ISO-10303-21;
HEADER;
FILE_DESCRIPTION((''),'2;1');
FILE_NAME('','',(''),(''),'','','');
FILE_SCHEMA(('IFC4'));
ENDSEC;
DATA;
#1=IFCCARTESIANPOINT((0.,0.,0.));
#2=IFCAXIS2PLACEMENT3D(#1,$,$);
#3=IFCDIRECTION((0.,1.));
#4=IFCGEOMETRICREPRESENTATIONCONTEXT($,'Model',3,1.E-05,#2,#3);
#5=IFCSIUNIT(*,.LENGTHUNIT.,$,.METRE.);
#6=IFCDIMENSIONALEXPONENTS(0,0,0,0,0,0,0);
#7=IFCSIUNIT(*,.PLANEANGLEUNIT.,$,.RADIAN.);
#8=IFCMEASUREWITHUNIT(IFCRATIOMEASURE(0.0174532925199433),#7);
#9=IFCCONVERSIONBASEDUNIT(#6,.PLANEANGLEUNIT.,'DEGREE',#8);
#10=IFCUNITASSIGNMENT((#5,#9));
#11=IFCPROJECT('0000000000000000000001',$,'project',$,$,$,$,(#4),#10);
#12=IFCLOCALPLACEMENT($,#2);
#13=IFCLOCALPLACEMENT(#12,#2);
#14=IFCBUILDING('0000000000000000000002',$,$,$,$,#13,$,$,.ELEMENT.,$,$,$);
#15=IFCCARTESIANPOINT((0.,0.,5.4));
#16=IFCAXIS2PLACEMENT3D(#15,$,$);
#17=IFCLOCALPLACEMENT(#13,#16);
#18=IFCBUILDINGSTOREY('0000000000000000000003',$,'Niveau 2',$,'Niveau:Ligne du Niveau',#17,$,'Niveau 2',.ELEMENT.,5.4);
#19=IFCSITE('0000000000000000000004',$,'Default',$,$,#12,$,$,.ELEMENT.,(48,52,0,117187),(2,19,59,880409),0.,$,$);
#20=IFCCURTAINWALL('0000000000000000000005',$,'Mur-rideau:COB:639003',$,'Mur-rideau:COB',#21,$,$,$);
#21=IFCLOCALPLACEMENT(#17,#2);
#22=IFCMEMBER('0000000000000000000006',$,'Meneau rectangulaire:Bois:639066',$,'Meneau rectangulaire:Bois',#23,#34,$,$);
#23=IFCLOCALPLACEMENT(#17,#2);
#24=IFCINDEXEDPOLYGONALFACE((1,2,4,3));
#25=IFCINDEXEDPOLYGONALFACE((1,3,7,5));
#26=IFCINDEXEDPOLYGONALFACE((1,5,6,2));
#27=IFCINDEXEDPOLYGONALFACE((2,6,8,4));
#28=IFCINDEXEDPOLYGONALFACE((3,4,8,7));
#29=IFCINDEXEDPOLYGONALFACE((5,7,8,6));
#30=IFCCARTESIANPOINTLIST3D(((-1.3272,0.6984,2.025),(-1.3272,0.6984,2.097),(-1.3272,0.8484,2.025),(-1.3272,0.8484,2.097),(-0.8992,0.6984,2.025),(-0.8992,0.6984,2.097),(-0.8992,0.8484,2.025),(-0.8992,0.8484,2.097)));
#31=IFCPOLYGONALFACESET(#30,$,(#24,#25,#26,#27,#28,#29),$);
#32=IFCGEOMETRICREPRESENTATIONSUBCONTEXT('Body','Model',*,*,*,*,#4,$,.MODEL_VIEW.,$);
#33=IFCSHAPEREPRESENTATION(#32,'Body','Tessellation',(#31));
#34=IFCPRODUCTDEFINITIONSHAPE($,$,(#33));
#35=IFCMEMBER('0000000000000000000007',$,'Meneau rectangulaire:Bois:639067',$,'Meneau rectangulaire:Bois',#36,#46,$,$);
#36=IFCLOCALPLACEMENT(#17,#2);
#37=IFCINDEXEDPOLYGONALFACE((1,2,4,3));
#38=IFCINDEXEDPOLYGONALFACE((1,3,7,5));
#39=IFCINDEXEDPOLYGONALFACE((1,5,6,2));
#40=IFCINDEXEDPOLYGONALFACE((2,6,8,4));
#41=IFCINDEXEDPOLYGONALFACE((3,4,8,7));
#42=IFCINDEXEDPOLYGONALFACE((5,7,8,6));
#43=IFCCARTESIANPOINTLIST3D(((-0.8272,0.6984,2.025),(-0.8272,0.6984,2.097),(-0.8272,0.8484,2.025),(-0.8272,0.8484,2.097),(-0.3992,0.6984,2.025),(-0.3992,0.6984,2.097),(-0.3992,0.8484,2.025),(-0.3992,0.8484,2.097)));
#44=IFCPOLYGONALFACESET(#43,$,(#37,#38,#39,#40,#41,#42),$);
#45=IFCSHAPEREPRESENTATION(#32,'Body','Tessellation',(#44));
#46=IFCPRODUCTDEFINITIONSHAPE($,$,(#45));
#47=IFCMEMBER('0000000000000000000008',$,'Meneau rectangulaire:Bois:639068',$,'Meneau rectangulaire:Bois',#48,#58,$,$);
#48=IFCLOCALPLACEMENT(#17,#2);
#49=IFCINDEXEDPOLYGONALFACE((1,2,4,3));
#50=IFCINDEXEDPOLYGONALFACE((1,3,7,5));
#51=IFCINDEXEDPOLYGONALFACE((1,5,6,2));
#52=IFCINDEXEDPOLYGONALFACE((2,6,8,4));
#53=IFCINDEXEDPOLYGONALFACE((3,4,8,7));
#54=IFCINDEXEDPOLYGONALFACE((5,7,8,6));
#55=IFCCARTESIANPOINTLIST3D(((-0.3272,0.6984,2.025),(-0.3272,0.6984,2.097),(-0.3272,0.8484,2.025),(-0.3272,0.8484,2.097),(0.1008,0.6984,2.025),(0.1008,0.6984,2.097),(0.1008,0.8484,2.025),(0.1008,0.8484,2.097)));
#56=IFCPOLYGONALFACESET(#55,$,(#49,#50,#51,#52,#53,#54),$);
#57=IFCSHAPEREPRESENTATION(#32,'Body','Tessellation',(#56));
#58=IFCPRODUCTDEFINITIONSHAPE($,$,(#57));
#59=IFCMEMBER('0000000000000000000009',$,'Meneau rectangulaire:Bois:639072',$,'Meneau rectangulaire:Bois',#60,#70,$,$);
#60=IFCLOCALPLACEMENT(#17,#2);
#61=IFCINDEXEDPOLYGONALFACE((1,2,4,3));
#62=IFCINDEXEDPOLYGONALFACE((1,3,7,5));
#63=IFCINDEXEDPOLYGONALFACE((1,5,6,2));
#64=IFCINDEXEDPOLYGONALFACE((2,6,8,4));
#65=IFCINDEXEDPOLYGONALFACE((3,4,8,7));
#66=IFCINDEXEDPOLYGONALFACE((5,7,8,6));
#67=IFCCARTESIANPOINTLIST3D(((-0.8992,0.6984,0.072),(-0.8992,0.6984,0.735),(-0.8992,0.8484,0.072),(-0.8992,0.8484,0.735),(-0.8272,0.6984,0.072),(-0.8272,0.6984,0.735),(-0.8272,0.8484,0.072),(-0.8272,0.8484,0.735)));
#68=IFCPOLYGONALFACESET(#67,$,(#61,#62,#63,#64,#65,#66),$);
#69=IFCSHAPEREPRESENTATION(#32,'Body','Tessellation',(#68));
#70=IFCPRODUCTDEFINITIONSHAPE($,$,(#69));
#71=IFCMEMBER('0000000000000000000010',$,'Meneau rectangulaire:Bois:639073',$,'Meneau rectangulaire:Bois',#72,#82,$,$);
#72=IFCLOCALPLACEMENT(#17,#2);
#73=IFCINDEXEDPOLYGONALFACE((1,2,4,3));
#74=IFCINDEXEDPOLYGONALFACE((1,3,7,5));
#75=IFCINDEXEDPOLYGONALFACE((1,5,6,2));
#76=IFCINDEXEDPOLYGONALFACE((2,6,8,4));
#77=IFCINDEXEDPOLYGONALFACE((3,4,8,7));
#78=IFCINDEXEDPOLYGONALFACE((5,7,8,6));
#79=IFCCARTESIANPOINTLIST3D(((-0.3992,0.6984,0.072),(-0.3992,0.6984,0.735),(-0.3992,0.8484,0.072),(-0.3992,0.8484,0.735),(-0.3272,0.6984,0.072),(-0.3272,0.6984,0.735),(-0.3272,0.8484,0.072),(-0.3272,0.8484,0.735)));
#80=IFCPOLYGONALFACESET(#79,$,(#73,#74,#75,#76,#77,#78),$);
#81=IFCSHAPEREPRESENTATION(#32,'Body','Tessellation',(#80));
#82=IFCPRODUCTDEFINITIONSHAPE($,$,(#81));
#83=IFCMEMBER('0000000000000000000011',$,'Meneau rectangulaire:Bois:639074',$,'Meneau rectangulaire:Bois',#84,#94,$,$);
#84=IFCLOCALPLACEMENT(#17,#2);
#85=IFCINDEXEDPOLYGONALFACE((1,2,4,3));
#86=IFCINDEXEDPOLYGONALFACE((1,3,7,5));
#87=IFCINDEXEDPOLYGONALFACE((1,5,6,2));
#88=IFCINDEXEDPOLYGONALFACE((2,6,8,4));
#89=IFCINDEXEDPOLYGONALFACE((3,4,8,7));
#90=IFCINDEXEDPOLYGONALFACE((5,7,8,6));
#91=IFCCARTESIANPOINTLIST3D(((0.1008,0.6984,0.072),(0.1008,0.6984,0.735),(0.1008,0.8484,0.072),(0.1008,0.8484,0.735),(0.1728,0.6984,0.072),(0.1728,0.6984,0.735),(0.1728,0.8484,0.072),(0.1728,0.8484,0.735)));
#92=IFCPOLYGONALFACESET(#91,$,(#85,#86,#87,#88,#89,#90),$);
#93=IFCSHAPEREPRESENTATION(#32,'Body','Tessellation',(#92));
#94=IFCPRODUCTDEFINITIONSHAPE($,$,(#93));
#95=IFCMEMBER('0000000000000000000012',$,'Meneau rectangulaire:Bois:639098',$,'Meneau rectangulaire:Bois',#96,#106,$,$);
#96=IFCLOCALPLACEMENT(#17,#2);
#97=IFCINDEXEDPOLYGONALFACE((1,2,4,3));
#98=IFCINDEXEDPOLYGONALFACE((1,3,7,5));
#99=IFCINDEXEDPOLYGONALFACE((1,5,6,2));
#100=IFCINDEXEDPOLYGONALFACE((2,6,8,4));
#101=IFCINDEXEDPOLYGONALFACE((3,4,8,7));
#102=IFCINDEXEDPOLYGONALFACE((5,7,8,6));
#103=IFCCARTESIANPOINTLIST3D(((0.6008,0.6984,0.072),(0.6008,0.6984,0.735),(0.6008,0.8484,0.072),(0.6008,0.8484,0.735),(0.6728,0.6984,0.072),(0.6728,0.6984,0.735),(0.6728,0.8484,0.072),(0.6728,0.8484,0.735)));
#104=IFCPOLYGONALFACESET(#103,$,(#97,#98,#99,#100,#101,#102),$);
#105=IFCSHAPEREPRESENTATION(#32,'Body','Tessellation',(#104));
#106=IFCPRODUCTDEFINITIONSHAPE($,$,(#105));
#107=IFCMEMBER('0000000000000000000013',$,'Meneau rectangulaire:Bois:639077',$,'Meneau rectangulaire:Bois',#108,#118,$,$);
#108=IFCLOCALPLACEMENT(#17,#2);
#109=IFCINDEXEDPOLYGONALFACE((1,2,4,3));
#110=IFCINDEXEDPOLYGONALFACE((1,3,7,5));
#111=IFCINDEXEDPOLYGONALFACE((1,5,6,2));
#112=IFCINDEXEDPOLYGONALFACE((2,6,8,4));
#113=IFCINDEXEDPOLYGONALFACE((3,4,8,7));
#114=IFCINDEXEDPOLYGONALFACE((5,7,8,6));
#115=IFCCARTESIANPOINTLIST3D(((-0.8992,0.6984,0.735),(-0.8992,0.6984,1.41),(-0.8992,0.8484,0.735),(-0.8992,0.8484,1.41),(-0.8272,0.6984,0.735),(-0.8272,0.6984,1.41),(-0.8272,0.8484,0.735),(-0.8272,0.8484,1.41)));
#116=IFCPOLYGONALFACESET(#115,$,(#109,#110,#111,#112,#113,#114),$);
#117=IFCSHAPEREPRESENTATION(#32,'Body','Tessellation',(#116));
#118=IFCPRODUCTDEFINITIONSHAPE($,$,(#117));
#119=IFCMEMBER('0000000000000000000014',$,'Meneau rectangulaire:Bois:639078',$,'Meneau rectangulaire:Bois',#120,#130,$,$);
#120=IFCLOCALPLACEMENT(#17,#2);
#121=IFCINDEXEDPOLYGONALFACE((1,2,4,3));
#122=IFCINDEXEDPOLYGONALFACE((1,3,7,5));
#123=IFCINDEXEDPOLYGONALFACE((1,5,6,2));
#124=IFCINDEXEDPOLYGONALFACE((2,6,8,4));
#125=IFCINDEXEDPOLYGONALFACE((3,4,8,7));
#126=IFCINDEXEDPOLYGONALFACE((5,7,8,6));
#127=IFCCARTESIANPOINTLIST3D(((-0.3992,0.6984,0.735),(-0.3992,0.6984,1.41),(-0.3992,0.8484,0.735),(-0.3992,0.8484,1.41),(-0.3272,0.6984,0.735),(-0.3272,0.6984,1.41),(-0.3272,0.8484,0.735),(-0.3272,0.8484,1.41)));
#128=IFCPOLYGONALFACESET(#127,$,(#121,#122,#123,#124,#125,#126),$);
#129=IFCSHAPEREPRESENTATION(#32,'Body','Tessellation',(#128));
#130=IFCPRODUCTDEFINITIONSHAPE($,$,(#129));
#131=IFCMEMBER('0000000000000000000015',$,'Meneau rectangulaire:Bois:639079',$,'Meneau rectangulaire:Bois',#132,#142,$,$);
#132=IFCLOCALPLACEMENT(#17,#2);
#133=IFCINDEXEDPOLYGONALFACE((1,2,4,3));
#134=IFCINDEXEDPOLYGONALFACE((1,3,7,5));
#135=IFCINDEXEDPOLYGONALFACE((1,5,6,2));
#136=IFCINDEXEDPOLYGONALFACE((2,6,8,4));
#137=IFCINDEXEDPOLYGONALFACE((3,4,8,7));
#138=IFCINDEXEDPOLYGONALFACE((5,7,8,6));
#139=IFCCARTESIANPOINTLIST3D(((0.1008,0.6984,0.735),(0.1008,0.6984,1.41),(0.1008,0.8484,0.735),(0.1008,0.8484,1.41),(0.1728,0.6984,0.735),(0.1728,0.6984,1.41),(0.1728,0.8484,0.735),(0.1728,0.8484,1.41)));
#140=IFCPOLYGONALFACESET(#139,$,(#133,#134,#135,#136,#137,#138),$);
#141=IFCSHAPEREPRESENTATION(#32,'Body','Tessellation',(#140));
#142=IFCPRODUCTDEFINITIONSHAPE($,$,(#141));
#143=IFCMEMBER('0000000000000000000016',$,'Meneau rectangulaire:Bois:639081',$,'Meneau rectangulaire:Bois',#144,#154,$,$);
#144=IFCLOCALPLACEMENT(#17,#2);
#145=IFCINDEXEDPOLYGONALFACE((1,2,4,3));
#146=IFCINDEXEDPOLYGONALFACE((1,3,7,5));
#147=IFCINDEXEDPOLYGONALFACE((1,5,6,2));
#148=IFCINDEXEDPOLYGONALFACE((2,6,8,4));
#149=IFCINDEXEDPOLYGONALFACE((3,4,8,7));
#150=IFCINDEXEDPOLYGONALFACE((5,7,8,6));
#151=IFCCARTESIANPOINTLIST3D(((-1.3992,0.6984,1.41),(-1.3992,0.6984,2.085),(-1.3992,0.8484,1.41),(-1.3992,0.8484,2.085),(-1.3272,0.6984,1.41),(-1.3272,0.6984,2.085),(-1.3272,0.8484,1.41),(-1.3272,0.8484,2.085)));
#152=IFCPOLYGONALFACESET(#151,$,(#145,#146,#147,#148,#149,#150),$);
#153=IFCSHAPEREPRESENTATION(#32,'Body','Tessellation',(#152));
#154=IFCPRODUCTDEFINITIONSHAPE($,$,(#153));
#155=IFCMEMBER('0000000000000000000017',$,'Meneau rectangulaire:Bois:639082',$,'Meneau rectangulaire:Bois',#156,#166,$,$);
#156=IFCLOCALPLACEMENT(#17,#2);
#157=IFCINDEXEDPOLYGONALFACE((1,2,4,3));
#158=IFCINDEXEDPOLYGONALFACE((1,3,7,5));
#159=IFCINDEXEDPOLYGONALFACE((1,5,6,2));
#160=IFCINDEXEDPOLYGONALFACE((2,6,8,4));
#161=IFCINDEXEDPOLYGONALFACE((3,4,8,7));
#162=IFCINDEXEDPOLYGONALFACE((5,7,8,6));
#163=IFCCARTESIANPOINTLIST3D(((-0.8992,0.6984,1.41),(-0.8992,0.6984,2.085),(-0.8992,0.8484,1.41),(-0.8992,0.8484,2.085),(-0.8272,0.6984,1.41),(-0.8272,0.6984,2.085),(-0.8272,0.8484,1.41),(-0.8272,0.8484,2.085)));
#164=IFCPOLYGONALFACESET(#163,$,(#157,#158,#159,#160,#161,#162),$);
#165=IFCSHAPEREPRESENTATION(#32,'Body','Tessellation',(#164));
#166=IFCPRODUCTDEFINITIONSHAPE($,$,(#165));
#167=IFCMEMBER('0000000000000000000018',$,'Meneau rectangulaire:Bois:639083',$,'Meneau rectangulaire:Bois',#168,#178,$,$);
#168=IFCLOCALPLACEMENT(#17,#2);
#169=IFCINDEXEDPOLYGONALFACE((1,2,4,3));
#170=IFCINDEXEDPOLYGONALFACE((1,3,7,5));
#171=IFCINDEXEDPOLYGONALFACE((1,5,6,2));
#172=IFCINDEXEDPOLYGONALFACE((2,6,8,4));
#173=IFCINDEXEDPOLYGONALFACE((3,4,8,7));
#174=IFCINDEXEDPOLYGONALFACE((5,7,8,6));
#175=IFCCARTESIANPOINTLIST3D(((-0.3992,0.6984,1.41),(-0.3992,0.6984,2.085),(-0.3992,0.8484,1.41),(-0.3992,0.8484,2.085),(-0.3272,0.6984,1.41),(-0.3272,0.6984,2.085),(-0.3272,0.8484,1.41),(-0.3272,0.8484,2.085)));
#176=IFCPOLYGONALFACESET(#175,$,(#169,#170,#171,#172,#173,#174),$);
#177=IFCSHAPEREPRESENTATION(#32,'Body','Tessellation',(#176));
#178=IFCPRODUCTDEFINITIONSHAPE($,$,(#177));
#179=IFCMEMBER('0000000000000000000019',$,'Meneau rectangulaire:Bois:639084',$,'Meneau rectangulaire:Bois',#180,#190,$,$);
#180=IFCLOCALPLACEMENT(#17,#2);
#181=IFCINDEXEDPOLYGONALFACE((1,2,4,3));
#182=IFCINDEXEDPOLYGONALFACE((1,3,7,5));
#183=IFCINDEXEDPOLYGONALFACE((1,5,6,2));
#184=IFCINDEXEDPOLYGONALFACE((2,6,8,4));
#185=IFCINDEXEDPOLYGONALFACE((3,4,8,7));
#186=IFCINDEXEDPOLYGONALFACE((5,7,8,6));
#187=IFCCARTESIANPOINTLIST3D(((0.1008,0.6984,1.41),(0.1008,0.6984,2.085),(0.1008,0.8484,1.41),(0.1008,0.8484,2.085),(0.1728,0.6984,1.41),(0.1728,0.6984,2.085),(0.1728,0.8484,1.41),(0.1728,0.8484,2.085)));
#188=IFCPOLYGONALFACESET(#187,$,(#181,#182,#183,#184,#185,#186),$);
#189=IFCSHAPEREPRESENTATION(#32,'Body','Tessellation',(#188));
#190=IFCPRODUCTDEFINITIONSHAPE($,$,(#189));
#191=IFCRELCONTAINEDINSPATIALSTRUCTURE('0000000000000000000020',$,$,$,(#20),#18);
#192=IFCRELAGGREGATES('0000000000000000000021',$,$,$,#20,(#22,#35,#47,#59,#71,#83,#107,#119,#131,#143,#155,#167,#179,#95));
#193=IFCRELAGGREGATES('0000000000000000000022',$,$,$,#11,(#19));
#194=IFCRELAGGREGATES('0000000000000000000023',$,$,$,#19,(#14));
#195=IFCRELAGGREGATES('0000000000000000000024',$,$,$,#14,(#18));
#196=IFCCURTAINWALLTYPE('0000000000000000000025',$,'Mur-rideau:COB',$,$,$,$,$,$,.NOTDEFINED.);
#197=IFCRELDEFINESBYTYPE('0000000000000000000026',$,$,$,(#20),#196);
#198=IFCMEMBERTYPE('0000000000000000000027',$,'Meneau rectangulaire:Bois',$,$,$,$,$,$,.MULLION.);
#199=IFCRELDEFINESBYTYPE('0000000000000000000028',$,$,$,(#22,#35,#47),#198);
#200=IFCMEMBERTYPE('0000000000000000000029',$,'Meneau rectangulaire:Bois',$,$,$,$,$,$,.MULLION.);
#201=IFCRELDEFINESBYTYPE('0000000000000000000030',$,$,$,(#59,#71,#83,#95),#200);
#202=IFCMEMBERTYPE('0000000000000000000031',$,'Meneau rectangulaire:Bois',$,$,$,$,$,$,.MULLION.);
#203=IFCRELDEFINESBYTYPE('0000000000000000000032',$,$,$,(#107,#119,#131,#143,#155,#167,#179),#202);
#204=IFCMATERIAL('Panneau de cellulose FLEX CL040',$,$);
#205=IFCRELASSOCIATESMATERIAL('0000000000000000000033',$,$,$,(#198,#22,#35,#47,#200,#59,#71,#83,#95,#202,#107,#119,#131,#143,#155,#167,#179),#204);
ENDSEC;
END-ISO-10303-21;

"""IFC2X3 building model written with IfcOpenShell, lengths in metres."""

from ifc_helpers import new_model, entity, si_unit, converted_unit, direction, frame, origin, origin_2d_with_axis, place, context, subcontext, project, spatial, rectangle, extrude, source, transform, mapped, material, type_object, type_shapes, element, aggregate, save


model = new_model("IFC2X3")

# Units and contexts
model_context = context("Model", 3, precision=1e-05, world=origin(), true_north=direction((0.0, 1.0)))
body_context = subcontext(model_context, "Body", "Model", "MODEL_VIEW")
ifc_project = project(units=[si_unit("LENGTHUNIT", "METRE"), converted_unit("PLANEANGLEUNIT", "DEGREE", entity("IfcRatioMeasure", 0.0174532925199433), si_unit("PLANEANGLEUNIT", "RADIAN"), dimensions=[0, 0, 0, 0, 0, 0, 0])], contexts=[model_context])

# Site, building, storey
site_placement = place(None, origin())
site = spatial("IfcSite", under=ifc_project, at=site_placement, Name="Default", CompositionType="ELEMENT", RefLatitude=(48, 52, 0, 117187), RefLongitude=(2, 19, 59, 880409), RefElevation=0.0)
building_placement = place(site_placement, origin())
building = spatial("IfcBuilding", under=site, at=building_placement, CompositionType="ELEMENT")
storey_placement = place(building_placement, frame((0.0, 0.0, 5.4)))
storey = spatial("IfcBuildingStorey", under=building, at=storey_placement, Name="Niveau 2", ObjectType="Niveau:Ligne du Niveau", LongName="Niveau 2", CompositionType="ELEMENT", Elevation=5.4)

# Curtain wall, members
curtain_wall_type_1 = type_object("IfcCurtainWallType", Name="Mur-rideau:COB", PredefinedType="NOTDEFINED")
curtain_wall_1_placement = place(storey_placement, frame((0.0, 0.0, -5.4)))
curtain_wall_1 = element("IfcCurtainWall", 1, at=curtain_wall_1_placement, inside=storey, type_object=curtain_wall_type_1, Name="Mur-rideau:COB:639003", ObjectType="Mur-rideau:COB")
ifc_material_1 = material(Name="Panneau de cellulose FLEX CL040")
member_type_1 = type_object("IfcMemberType", Name="Meneau rectangulaire:Bois", PredefinedType="MULLION", material=ifc_material_1)
shared_shape_1 = source(origin(), body_context, "Body", "SweptSolid", [
    extrude(rectangle(XDim=0.15, YDim=0.072, at=origin_2d_with_axis()), frame((-0.024, 0.0, -0.428), z_axis=(0.0, 0.0, 1.0), x_axis=(0.0, -1.0, 0.0)), (0.0, 0.0, 1.0), 0.428),
])
type_shapes(member_type_1, [shared_shape_1])
member_1_placement = place(storey_placement, frame((-0.8992, 0.7734, 2.085), z_axis=(1.0, 0.0, 0.0), x_axis=(0.0, 0.0, 1.0)))
member_1 = element("IfcMember", 2, at=member_1_placement, type_object=member_type_1, material=ifc_material_1, Name="Meneau rectangulaire:Bois:639066", ObjectType="Meneau rectangulaire:Bois", context=body_context, shape_type="MappedRepresentation", body=[
    mapped(shared_shape_1, transform((0.0, 0.0, 0.0), scale=1.0)),
])
member_2_placement = place(storey_placement, frame((-0.3992, 0.7734, 2.085), z_axis=(1.0, 0.0, 0.0), x_axis=(0.0, 0.0, 1.0)))
member_2 = element("IfcMember", 3, at=member_2_placement, type_object=member_type_1, material=ifc_material_1, Name="Meneau rectangulaire:Bois:639067", ObjectType="Meneau rectangulaire:Bois", context=body_context, shape_type="MappedRepresentation", body=[
    mapped(shared_shape_1, transform((0.0, 0.0, 0.0), scale=1.0)),
])
member_3_placement = place(storey_placement, frame((0.1008, 0.7734, 2.085), z_axis=(1.0, 0.0, 0.0), x_axis=(0.0, 0.0, 1.0)))
member_3 = element("IfcMember", 4, at=member_3_placement, type_object=member_type_1, material=ifc_material_1, Name="Meneau rectangulaire:Bois:639068", ObjectType="Meneau rectangulaire:Bois", context=body_context, shape_type="MappedRepresentation", body=[
    mapped(shared_shape_1, transform((0.0, 0.0, 0.0), scale=1.0)),
])
member_type_2 = type_object("IfcMemberType", Name="Meneau rectangulaire:Bois", PredefinedType="MULLION", material=ifc_material_1)
shared_shape_2 = source(origin(), body_context, "Body", "SweptSolid", [
    extrude(rectangle(XDim=0.15, YDim=0.072, at=origin_2d_with_axis()), frame((-0.024, 0.0, -0.663), z_axis=(0.0, 0.0, 1.0), x_axis=(0.0, -1.0, 0.0)), (0.0, 0.0, 1.0), 0.663),
])
type_shapes(member_type_2, [shared_shape_2])
member_4_placement = place(storey_placement, frame((-0.8392, 0.7734, 0.072), z_axis=(0.0, 0.0, -1.0), x_axis=(1.0, 0.0, 0.0)))
member_4 = element("IfcMember", 5, at=member_4_placement, type_object=member_type_2, material=ifc_material_1, Name="Meneau rectangulaire:Bois:639072", ObjectType="Meneau rectangulaire:Bois", context=body_context, shape_type="MappedRepresentation", body=[
    mapped(shared_shape_2, transform((0.0, 0.0, 0.0), scale=1.0)),
])
member_5_placement = place(storey_placement, frame((-0.3392, 0.7734, 0.072), z_axis=(0.0, 0.0, -1.0), x_axis=(1.0, 0.0, 0.0)))
member_5 = element("IfcMember", 6, at=member_5_placement, type_object=member_type_2, material=ifc_material_1, Name="Meneau rectangulaire:Bois:639073", ObjectType="Meneau rectangulaire:Bois", context=body_context, shape_type="MappedRepresentation", body=[
    mapped(shared_shape_2, transform((0.0, 0.0, 0.0), scale=1.0)),
])
member_6_placement = place(storey_placement, frame((0.1608, 0.7734, 0.072), z_axis=(0.0, 0.0, -1.0), x_axis=(1.0, 0.0, 0.0)))
member_6 = element("IfcMember", 7, at=member_6_placement, type_object=member_type_2, material=ifc_material_1, Name="Meneau rectangulaire:Bois:639074", ObjectType="Meneau rectangulaire:Bois", context=body_context, shape_type="MappedRepresentation", body=[
    mapped(shared_shape_2, transform((0.0, 0.0, 0.0), scale=1.0)),
])
member_7_placement = place(storey_placement, frame((0.6608, 0.7734, 0.072), z_axis=(0.0, 0.0, -1.0), x_axis=(1.0, 0.0, 0.0)))
member_7 = element("IfcMember", 8, at=member_7_placement, type_object=member_type_2, material=ifc_material_1, Name="Meneau rectangulaire:Bois:639098", ObjectType="Meneau rectangulaire:Bois", context=body_context, shape_type="MappedRepresentation", body=[
    mapped(shared_shape_2, transform((0.0, 0.0, 0.0), scale=1.0)),
])
member_type_3 = type_object("IfcMemberType", Name="Meneau rectangulaire:Bois", PredefinedType="MULLION", material=ifc_material_1)
shared_shape_3 = source(origin(), body_context, "Body", "SweptSolid", [
    extrude(rectangle(XDim=0.15, YDim=0.072, at=origin_2d_with_axis()), frame((-0.024, 0.0, -0.675), z_axis=(0.0, 0.0, 1.0), x_axis=(0.0, -1.0, 0.0)), (0.0, 0.0, 1.0), 0.675),
])
type_shapes(member_type_3, [shared_shape_3])
member_8_placement = place(storey_placement, frame((-0.8392, 0.7734, 0.735), z_axis=(0.0, 0.0, -1.0), x_axis=(1.0, 0.0, 0.0)))
member_8 = element("IfcMember", 9, at=member_8_placement, type_object=member_type_3, material=ifc_material_1, Name="Meneau rectangulaire:Bois:639077", ObjectType="Meneau rectangulaire:Bois", context=body_context, shape_type="MappedRepresentation", body=[
    mapped(shared_shape_3, transform((0.0, 0.0, 0.0), scale=1.0)),
])
member_9_placement = place(storey_placement, frame((-0.3392, 0.7734, 0.735), z_axis=(0.0, 0.0, -1.0), x_axis=(1.0, 0.0, 0.0)))
member_9 = element("IfcMember", 10, at=member_9_placement, type_object=member_type_3, material=ifc_material_1, Name="Meneau rectangulaire:Bois:639078", ObjectType="Meneau rectangulaire:Bois", context=body_context, shape_type="MappedRepresentation", body=[
    mapped(shared_shape_3, transform((0.0, 0.0, 0.0), scale=1.0)),
])
member_10_placement = place(storey_placement, frame((0.1608, 0.7734, 0.735), z_axis=(0.0, 0.0, -1.0), x_axis=(1.0, 0.0, 0.0)))
member_10 = element("IfcMember", 11, at=member_10_placement, type_object=member_type_3, material=ifc_material_1, Name="Meneau rectangulaire:Bois:639079", ObjectType="Meneau rectangulaire:Bois", context=body_context, shape_type="MappedRepresentation", body=[
    mapped(shared_shape_3, transform((0.0, 0.0, 0.0), scale=1.0)),
])
member_11_placement = place(storey_placement, frame((-1.3392, 0.7734, 1.41), z_axis=(0.0, 0.0, -1.0), x_axis=(1.0, 0.0, 0.0)))
member_11 = element("IfcMember", 12, at=member_11_placement, type_object=member_type_3, material=ifc_material_1, Name="Meneau rectangulaire:Bois:639081", ObjectType="Meneau rectangulaire:Bois", context=body_context, shape_type="MappedRepresentation", body=[
    mapped(shared_shape_3, transform((0.0, 0.0, 0.0), scale=1.0)),
])
member_12_placement = place(storey_placement, frame((-0.8392, 0.7734, 1.41), z_axis=(0.0, 0.0, -1.0), x_axis=(1.0, 0.0, 0.0)))
member_12 = element("IfcMember", 13, at=member_12_placement, type_object=member_type_3, material=ifc_material_1, Name="Meneau rectangulaire:Bois:639082", ObjectType="Meneau rectangulaire:Bois", context=body_context, shape_type="MappedRepresentation", body=[
    mapped(shared_shape_3, transform((0.0, 0.0, 0.0), scale=1.0)),
])
member_13_placement = place(storey_placement, frame((-0.3392, 0.7734, 1.41), z_axis=(0.0, 0.0, -1.0), x_axis=(1.0, 0.0, 0.0)))
member_13 = element("IfcMember", 14, at=member_13_placement, type_object=member_type_3, material=ifc_material_1, Name="Meneau rectangulaire:Bois:639083", ObjectType="Meneau rectangulaire:Bois", context=body_context, shape_type="MappedRepresentation", body=[
    mapped(shared_shape_3, transform((0.0, 0.0, 0.0), scale=1.0)),
])
member_14_placement = place(storey_placement, frame((0.1608, 0.7734, 1.41), z_axis=(0.0, 0.0, -1.0), x_axis=(1.0, 0.0, 0.0)))
member_14 = element("IfcMember", 15, at=member_14_placement, type_object=member_type_3, material=ifc_material_1, Name="Meneau rectangulaire:Bois:639084", ObjectType="Meneau rectangulaire:Bois", context=body_context, shape_type="MappedRepresentation", body=[
    mapped(shared_shape_3, transform((0.0, 0.0, 0.0), scale=1.0)),
])
aggregate(curtain_wall_1, [member_1, member_2, member_3, member_4, member_5, member_6, member_8, member_9, member_10, member_11, member_12, member_13, member_14, member_7])

save(model, "model.ifc")
